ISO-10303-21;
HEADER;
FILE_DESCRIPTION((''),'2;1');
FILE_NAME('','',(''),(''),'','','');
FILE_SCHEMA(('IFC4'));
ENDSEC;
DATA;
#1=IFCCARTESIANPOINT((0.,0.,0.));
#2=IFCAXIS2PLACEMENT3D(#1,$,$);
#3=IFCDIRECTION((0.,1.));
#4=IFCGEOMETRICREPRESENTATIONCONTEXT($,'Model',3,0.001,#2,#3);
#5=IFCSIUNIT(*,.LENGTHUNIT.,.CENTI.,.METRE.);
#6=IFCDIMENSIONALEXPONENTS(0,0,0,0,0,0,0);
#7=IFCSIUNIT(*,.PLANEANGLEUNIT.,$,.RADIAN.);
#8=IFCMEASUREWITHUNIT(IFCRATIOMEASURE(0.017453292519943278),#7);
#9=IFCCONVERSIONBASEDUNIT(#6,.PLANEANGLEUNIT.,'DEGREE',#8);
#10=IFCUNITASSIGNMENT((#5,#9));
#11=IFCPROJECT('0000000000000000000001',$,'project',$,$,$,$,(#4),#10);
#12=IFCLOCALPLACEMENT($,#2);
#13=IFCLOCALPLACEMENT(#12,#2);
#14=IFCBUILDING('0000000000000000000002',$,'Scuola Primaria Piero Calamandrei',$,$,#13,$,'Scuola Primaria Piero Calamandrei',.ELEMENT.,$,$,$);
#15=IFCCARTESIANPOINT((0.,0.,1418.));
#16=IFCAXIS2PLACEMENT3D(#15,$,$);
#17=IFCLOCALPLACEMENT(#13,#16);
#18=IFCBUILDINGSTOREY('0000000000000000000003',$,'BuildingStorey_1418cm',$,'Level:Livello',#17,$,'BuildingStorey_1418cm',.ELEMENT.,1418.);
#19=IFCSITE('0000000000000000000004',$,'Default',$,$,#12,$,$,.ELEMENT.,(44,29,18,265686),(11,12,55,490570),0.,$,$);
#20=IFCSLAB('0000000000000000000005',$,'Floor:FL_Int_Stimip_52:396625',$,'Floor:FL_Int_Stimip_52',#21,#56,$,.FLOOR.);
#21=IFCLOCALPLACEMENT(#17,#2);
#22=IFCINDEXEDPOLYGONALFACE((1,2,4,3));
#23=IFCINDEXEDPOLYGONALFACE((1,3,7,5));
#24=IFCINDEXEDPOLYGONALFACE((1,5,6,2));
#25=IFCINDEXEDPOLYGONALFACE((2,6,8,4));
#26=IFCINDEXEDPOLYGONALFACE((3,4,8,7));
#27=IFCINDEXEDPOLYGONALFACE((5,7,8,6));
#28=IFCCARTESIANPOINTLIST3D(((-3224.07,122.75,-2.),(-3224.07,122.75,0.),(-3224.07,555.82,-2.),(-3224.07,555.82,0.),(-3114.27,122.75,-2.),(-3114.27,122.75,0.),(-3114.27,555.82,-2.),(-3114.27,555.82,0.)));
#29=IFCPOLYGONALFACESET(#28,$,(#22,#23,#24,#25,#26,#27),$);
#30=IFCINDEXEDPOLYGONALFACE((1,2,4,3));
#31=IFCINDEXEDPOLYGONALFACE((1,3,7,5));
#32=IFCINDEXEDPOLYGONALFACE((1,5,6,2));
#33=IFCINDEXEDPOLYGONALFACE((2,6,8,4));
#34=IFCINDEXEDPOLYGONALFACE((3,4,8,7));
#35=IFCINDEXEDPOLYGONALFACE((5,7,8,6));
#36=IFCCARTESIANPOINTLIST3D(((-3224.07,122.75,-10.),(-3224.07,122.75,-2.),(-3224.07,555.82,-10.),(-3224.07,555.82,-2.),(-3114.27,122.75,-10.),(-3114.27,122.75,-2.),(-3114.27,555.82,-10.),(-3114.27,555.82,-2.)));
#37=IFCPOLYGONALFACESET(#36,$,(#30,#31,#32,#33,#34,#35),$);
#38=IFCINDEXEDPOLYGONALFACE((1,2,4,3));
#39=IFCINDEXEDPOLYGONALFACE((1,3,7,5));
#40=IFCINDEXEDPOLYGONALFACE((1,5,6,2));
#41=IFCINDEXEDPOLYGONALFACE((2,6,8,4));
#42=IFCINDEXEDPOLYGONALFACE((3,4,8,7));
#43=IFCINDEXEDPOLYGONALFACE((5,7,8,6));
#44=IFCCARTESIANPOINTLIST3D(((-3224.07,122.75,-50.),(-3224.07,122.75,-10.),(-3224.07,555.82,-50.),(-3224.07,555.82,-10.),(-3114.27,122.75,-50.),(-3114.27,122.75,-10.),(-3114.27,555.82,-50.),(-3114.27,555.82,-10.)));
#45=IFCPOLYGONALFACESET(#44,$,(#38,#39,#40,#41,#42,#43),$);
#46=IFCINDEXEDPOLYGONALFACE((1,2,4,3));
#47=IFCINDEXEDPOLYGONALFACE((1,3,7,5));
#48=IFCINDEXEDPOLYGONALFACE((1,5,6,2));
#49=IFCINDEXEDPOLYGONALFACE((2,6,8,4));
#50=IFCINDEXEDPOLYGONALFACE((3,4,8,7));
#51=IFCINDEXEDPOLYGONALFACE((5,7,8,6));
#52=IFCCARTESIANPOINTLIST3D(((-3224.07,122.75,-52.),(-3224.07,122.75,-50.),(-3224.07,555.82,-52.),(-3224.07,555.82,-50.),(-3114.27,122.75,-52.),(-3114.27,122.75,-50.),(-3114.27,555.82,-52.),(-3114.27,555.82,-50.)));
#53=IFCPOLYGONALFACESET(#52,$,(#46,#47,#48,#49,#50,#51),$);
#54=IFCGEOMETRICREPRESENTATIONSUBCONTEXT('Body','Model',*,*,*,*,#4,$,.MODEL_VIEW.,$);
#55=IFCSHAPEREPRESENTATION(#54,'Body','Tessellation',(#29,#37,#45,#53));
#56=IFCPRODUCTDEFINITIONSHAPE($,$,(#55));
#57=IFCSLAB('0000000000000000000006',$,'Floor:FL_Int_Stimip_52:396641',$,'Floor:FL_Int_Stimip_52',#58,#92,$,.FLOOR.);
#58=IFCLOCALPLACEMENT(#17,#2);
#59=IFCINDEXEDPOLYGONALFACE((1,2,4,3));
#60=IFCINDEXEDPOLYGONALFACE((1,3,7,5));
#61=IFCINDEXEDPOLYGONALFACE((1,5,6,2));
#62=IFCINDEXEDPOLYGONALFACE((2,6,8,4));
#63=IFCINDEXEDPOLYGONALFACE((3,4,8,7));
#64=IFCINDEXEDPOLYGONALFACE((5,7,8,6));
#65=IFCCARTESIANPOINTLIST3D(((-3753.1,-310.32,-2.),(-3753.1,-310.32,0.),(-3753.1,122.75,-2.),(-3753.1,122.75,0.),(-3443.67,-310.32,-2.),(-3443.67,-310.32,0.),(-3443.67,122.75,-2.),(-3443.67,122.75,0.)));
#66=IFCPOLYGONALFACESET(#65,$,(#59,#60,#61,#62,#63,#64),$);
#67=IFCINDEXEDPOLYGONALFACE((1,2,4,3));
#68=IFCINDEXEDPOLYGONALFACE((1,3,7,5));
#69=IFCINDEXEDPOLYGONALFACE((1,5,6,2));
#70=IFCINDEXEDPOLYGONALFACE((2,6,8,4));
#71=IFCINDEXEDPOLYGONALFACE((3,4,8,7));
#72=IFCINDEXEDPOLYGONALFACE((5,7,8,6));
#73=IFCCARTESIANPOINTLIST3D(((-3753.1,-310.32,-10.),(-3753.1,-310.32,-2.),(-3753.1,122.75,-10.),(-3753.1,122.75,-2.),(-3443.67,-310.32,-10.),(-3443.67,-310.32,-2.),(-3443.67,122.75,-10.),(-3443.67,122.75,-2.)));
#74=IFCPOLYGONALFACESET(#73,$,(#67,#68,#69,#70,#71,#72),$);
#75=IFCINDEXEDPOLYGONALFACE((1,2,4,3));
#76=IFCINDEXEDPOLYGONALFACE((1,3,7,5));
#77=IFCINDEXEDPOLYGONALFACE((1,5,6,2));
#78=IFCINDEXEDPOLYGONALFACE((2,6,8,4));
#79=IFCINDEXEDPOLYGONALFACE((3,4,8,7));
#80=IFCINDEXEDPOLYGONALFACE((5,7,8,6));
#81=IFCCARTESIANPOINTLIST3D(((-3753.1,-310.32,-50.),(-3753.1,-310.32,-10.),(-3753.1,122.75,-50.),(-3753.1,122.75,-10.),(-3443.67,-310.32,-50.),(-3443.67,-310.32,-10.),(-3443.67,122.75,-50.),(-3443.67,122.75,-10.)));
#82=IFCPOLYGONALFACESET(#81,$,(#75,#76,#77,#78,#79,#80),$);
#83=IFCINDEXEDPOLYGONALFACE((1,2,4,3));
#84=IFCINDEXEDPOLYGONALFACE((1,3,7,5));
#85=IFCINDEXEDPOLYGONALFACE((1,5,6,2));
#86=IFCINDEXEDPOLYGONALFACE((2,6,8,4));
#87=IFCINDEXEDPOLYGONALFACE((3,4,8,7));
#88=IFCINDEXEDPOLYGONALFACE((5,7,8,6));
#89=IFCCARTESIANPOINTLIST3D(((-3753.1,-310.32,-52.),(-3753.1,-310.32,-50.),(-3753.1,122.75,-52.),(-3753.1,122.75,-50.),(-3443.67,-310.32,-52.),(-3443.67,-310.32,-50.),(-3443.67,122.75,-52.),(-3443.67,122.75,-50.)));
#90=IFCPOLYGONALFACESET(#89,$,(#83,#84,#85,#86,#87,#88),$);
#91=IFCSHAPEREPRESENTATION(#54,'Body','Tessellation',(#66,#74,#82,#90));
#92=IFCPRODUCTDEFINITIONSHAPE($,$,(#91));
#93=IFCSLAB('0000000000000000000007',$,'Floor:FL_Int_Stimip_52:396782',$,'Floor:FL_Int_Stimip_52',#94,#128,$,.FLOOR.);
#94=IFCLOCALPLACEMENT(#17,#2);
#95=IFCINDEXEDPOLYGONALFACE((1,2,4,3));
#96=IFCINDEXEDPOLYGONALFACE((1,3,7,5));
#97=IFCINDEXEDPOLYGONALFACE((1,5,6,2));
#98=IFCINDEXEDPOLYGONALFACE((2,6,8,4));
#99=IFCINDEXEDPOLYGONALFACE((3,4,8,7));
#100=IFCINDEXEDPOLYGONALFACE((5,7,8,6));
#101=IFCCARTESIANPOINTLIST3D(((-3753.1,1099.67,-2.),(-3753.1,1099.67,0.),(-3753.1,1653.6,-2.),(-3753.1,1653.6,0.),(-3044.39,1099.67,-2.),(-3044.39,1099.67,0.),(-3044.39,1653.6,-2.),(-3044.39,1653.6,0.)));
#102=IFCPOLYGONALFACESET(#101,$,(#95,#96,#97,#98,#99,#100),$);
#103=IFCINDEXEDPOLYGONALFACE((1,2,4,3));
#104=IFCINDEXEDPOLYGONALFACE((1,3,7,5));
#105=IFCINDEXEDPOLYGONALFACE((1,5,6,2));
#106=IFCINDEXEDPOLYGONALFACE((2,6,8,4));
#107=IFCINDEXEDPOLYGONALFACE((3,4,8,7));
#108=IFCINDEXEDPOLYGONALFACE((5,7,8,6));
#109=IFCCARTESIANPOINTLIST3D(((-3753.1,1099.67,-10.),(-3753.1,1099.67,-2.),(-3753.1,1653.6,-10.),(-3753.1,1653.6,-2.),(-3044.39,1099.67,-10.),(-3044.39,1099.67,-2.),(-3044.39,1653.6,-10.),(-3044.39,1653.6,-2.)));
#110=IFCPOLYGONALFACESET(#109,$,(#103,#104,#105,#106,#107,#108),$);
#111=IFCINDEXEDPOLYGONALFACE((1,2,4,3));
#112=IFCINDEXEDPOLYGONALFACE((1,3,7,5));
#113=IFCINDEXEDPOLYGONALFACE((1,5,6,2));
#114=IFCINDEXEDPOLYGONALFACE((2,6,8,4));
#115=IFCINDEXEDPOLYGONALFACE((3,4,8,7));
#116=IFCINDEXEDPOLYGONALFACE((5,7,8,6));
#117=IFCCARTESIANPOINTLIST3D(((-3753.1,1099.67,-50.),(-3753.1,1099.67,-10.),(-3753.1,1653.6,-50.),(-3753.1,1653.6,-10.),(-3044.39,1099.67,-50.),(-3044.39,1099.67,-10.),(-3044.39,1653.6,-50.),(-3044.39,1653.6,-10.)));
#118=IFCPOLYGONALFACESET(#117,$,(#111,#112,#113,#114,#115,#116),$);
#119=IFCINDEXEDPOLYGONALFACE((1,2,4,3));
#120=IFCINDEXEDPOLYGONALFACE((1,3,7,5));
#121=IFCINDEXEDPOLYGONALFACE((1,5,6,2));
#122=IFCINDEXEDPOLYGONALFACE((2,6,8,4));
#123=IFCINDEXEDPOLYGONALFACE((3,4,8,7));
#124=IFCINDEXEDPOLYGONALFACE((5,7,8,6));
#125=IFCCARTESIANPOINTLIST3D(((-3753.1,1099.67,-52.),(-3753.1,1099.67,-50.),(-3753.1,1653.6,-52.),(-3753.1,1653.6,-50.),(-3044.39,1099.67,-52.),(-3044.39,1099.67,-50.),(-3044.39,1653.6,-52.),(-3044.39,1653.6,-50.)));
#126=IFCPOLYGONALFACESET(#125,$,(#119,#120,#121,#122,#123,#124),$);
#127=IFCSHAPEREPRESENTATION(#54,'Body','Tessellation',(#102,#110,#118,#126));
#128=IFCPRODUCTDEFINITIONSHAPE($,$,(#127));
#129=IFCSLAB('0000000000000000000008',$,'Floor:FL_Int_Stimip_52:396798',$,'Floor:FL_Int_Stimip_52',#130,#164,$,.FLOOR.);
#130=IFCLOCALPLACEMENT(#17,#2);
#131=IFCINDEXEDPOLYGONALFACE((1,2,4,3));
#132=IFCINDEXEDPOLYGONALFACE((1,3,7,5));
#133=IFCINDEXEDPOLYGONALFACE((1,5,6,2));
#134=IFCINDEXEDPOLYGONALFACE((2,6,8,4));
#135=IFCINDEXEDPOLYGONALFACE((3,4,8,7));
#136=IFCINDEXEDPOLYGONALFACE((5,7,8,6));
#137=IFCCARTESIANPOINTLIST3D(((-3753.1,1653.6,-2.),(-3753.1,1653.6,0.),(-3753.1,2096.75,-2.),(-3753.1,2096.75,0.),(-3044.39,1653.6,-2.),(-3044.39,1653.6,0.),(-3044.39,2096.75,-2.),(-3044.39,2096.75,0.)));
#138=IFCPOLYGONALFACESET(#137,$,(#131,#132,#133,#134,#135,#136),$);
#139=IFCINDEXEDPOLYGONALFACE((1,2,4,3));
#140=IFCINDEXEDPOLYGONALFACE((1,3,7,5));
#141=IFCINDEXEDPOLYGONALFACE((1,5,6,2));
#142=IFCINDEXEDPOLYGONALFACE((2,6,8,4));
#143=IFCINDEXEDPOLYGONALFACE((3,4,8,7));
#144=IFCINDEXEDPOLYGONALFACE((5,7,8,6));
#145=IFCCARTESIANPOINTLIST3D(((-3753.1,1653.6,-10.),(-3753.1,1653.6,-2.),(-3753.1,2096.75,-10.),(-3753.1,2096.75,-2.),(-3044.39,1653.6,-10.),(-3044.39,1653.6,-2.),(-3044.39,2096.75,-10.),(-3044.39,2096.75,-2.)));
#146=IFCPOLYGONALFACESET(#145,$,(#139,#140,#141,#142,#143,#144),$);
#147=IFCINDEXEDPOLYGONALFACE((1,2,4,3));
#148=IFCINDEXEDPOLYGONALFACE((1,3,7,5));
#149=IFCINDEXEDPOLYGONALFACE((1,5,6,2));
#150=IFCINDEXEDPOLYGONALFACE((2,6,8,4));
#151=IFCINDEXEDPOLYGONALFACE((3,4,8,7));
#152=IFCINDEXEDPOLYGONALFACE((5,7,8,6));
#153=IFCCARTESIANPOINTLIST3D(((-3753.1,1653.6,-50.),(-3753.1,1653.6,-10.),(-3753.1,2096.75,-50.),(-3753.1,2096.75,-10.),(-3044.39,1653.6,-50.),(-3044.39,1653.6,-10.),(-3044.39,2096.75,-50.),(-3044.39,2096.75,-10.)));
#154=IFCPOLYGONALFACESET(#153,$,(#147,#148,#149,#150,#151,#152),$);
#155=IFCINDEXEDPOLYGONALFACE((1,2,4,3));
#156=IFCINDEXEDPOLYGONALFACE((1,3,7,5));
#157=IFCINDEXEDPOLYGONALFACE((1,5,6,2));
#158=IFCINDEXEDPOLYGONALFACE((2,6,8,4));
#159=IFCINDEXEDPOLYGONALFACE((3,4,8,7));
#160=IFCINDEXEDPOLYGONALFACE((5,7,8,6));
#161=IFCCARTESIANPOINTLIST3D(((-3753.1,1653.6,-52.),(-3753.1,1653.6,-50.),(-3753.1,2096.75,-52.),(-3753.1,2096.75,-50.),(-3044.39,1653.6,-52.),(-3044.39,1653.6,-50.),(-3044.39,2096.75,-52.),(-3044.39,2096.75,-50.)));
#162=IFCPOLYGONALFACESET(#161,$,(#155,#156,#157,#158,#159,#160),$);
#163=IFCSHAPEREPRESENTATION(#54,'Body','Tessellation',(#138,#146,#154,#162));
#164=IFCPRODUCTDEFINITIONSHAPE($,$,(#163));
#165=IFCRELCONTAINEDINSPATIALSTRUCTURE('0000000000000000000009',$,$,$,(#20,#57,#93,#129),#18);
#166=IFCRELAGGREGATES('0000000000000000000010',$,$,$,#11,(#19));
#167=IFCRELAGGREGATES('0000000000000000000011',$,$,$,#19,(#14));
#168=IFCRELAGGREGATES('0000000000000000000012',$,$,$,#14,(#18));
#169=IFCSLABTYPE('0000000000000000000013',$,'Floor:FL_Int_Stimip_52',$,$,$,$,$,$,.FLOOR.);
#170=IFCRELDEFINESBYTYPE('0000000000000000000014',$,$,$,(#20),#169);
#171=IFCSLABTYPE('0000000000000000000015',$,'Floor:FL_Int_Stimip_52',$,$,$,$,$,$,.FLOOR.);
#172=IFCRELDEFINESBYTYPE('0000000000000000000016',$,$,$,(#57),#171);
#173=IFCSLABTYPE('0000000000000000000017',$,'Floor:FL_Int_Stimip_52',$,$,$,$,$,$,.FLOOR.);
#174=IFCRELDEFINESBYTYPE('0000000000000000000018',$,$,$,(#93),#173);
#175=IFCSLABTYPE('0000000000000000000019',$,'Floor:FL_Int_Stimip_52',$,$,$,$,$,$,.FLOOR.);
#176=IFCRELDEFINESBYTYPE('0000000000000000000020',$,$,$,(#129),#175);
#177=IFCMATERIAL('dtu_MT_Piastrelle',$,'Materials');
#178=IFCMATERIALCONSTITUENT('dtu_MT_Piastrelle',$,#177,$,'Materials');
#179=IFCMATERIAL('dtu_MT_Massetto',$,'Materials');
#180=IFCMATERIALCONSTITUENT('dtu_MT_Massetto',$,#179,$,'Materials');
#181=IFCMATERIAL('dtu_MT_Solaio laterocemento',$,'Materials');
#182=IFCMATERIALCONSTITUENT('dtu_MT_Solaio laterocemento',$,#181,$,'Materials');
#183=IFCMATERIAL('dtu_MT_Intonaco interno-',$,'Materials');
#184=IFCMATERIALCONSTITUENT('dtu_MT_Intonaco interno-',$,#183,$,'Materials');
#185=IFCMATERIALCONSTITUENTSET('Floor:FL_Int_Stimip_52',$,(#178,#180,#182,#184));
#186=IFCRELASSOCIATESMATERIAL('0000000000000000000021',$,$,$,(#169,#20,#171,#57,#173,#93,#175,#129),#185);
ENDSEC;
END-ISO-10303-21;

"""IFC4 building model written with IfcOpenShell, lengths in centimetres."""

from ifc_helpers import new_model, entity, si_unit, converted_unit, direction, frame, origin, place, context, subcontext, project, spatial, indexed_curve, outline, extrude, material, constituent, constituent_set, type_object, element, save


model = new_model("IFC4")

# Units and contexts
model_context = context("Model", 3, precision=0.001, world=origin(), true_north=direction((0.0, 1.0)))
body_context = subcontext(model_context, "Body", "Model", "MODEL_VIEW")
ifc_project = project(units=[si_unit("LENGTHUNIT", "METRE", prefix="CENTI"), converted_unit("PLANEANGLEUNIT", "DEGREE", entity("IfcRatioMeasure", 0.017453292519943278), si_unit("PLANEANGLEUNIT", "RADIAN"), dimensions=[0, 0, 0, 0, 0, 0, 0])], contexts=[model_context])

# Site, building, storey
site_placement = place(None, origin())
site = spatial("IfcSite", under=ifc_project, at=site_placement, Name="Default", CompositionType="ELEMENT", RefLatitude=(44, 29, 18, 265686), RefLongitude=(11, 12, 55, 490570), RefElevation=0.0)
building_placement = place(site_placement, origin())
building = spatial("IfcBuilding", under=site, at=building_placement, Name="Scuola Primaria Piero Calamandrei", LongName="Scuola Primaria Piero Calamandrei", CompositionType="ELEMENT")
storey_placement = place(building_placement, frame((0.0, 0.0, 1418.0)))
storey = spatial("IfcBuildingStorey", under=building, at=storey_placement, Name="BuildingStorey_1418cm", ObjectType="Level:Livello", LongName="BuildingStorey_1418cm", CompositionType="ELEMENT", Elevation=1418.0)

# Slabs
ifc_material_1 = material(Name="dtu_MT_Piastrelle", Category="Materials")
ifc_constituent_1 = constituent(ifc_material_1, Name="dtu_MT_Piastrelle", Category="Materials")
ifc_material_2 = material(Name="dtu_MT_Massetto", Category="Materials")
ifc_constituent_2 = constituent(ifc_material_2, Name="dtu_MT_Massetto", Category="Materials")
ifc_material_3 = material(Name="dtu_MT_Solaio laterocemento", Category="Materials")
ifc_constituent_3 = constituent(ifc_material_3, Name="dtu_MT_Solaio laterocemento", Category="Materials")
ifc_material_4 = material(Name="dtu_MT_Intonaco interno-", Category="Materials")
ifc_constituent_4 = constituent(ifc_material_4, Name="dtu_MT_Intonaco interno-", Category="Materials")
ifc_constituent_set_1 = constituent_set(constituents=[ifc_constituent_1, ifc_constituent_2, ifc_constituent_3, ifc_constituent_4], Name="Floor:FL_Int_Stimip_52")
slab_type_1 = type_object("IfcSlabType", Name="Floor:FL_Int_Stimip_52", PredefinedType="FLOOR", material=ifc_constituent_set_1)
slab_1_placement = place(storey_placement, origin())
element("IfcSlab", 1, at=slab_1_placement, inside=storey, type_object=slab_type_1, material=ifc_constituent_set_1, Name="Floor:FL_Int_Stimip_52:396625", ObjectType="Floor:FL_Int_Stimip_52", PredefinedType="FLOOR", context=body_context, shape_type="SweptSolid", body=[
    extrude(outline(indexed_curve([(-54.9, -216.54), (54.9, -216.54), (54.9, 216.54), (-54.9, 216.54), (-54.9, -216.54)], self_intersect=False)), frame((-3169.17, 339.28, -2.0), z_axis=(0.0, 0.0, 1.0), x_axis=(-1.0, 0.0, 0.0)), (0.0, 0.0, 1.0), 2.0),
    extrude(outline(indexed_curve([(-54.9, -216.54), (54.9, -216.54), (54.9, 216.54), (-54.9, 216.54), (-54.9, -216.54)], self_intersect=False)), frame((-3169.17, 339.28, -10.0), z_axis=(0.0, 0.0, 1.0), x_axis=(-1.0, 0.0, 0.0)), (0.0, 0.0, 1.0), 8.0),
    extrude(outline(indexed_curve([(-54.9, -216.54), (54.9, -216.54), (54.9, 216.54), (-54.9, 216.54), (-54.9, -216.54)], self_intersect=False)), frame((-3169.17, 339.28, -50.0), z_axis=(0.0, 0.0, 1.0), x_axis=(-1.0, 0.0, 0.0)), (0.0, 0.0, 1.0), 40.0),
    extrude(outline(indexed_curve([(-54.9, -216.54), (54.9, -216.54), (54.9, 216.54), (-54.9, 216.54), (-54.9, -216.54)], self_intersect=False)), frame((-3169.17, 339.28, -52.0), z_axis=(0.0, 0.0, 1.0), x_axis=(-1.0, 0.0, 0.0)), (0.0, 0.0, 1.0), 2.0),
])
slab_type_2 = type_object("IfcSlabType", Name="Floor:FL_Int_Stimip_52", PredefinedType="FLOOR", material=ifc_constituent_set_1)
slab_2_placement = place(storey_placement, origin())
element("IfcSlab", 2, at=slab_2_placement, inside=storey, type_object=slab_type_2, material=ifc_constituent_set_1, Name="Floor:FL_Int_Stimip_52:396641", ObjectType="Floor:FL_Int_Stimip_52", PredefinedType="FLOOR", context=body_context, shape_type="SweptSolid", body=[
    extrude(outline(indexed_curve([(-154.72, -216.54), (154.72, -216.54), (154.72, 216.54), (-154.72, 216.54), (-154.72, -216.54)], self_intersect=False)), frame((-3598.38, -93.79, -2.0), z_axis=(0.0, 0.0, 1.0), x_axis=(-1.0, 0.0, 0.0)), (0.0, 0.0, 1.0), 2.0),
    extrude(outline(indexed_curve([(-154.72, -216.54), (154.72, -216.54), (154.72, 216.54), (-154.72, 216.54), (-154.72, -216.54)], self_intersect=False)), frame((-3598.38, -93.79, -10.0), z_axis=(0.0, 0.0, 1.0), x_axis=(-1.0, 0.0, 0.0)), (0.0, 0.0, 1.0), 8.0),
    extrude(outline(indexed_curve([(-154.72, -216.54), (154.72, -216.54), (154.72, 216.54), (-154.72, 216.54), (-154.72, -216.54)], self_intersect=False)), frame((-3598.38, -93.79, -50.0), z_axis=(0.0, 0.0, 1.0), x_axis=(-1.0, 0.0, 0.0)), (0.0, 0.0, 1.0), 40.0),
    extrude(outline(indexed_curve([(-154.72, -216.54), (154.72, -216.54), (154.72, 216.54), (-154.72, 216.54), (-154.72, -216.54)], self_intersect=False)), frame((-3598.38, -93.79, -52.0), z_axis=(0.0, 0.0, 1.0), x_axis=(-1.0, 0.0, 0.0)), (0.0, 0.0, 1.0), 2.0),
])
slab_type_3 = type_object("IfcSlabType", Name="Floor:FL_Int_Stimip_52", PredefinedType="FLOOR", material=ifc_constituent_set_1)
slab_3_placement = place(storey_placement, origin())
element("IfcSlab", 3, at=slab_3_placement, inside=storey, type_object=slab_type_3, material=ifc_constituent_set_1, Name="Floor:FL_Int_Stimip_52:396782", ObjectType="Floor:FL_Int_Stimip_52", PredefinedType="FLOOR", context=body_context, shape_type="SweptSolid", body=[
    extrude(outline(indexed_curve([(-354.35, -276.96), (354.35, -276.96), (354.35, 276.96), (-354.35, 276.96), (-354.35, -276.96)], self_intersect=False)), frame((-3398.75, 1376.64, -2.0), z_axis=(0.0, 0.0, 1.0), x_axis=(-1.0, 0.0, 0.0)), (0.0, 0.0, 1.0), 2.0),
    extrude(outline(indexed_curve([(-354.35, -276.96), (354.35, -276.96), (354.35, 276.96), (-354.35, 276.96), (-354.35, -276.96)], self_intersect=False)), frame((-3398.75, 1376.64, -10.0), z_axis=(0.0, 0.0, 1.0), x_axis=(-1.0, 0.0, 0.0)), (0.0, 0.0, 1.0), 8.0),
    extrude(outline(indexed_curve([(-354.35, -276.96), (354.35, -276.96), (354.35, 276.96), (-354.35, 276.96), (-354.35, -276.96)], self_intersect=False)), frame((-3398.75, 1376.64, -50.0), z_axis=(0.0, 0.0, 1.0), x_axis=(-1.0, 0.0, 0.0)), (0.0, 0.0, 1.0), 40.0),
    extrude(outline(indexed_curve([(-354.35, -276.96), (354.35, -276.96), (354.35, 276.96), (-354.35, 276.96), (-354.35, -276.96)], self_intersect=False)), frame((-3398.75, 1376.64, -52.0), z_axis=(0.0, 0.0, 1.0), x_axis=(-1.0, 0.0, 0.0)), (0.0, 0.0, 1.0), 2.0),
])
slab_type_4 = type_object("IfcSlabType", Name="Floor:FL_Int_Stimip_52", PredefinedType="FLOOR", material=ifc_constituent_set_1)
slab_4_placement = place(storey_placement, origin())
element("IfcSlab", 4, at=slab_4_placement, inside=storey, type_object=slab_type_4, material=ifc_constituent_set_1, Name="Floor:FL_Int_Stimip_52:396798", ObjectType="Floor:FL_Int_Stimip_52", PredefinedType="FLOOR", context=body_context, shape_type="SweptSolid", body=[
    extrude(outline(indexed_curve([(-354.35, -221.57), (354.35, -221.57), (354.35, 221.57), (-354.35, 221.57), (-354.35, -221.57)], self_intersect=False)), frame((-3398.75, 1875.17, -2.0), z_axis=(0.0, 0.0, 1.0), x_axis=(-1.0, 0.0, 0.0)), (0.0, 0.0, 1.0), 2.0),
    extrude(outline(indexed_curve([(-354.35, -221.57), (354.35, -221.57), (354.35, 221.57), (-354.35, 221.57), (-354.35, -221.57)], self_intersect=False)), frame((-3398.75, 1875.17, -10.0), z_axis=(0.0, 0.0, 1.0), x_axis=(-1.0, 0.0, 0.0)), (0.0, 0.0, 1.0), 8.0),
    extrude(outline(indexed_curve([(-354.35, -221.57), (354.35, -221.57), (354.35, 221.57), (-354.35, 221.57), (-354.35, -221.57)], self_intersect=False)), frame((-3398.75, 1875.17, -50.0), z_axis=(0.0, 0.0, 1.0), x_axis=(-1.0, 0.0, 0.0)), (0.0, 0.0, 1.0), 40.0),
    extrude(outline(indexed_curve([(-354.35, -221.57), (354.35, -221.57), (354.35, 221.57), (-354.35, 221.57), (-354.35, -221.57)], self_intersect=False)), frame((-3398.75, 1875.17, -52.0), z_axis=(0.0, 0.0, 1.0), x_axis=(-1.0, 0.0, 0.0)), (0.0, 0.0, 1.0), 2.0),
])

save(model, "model.ifc")
